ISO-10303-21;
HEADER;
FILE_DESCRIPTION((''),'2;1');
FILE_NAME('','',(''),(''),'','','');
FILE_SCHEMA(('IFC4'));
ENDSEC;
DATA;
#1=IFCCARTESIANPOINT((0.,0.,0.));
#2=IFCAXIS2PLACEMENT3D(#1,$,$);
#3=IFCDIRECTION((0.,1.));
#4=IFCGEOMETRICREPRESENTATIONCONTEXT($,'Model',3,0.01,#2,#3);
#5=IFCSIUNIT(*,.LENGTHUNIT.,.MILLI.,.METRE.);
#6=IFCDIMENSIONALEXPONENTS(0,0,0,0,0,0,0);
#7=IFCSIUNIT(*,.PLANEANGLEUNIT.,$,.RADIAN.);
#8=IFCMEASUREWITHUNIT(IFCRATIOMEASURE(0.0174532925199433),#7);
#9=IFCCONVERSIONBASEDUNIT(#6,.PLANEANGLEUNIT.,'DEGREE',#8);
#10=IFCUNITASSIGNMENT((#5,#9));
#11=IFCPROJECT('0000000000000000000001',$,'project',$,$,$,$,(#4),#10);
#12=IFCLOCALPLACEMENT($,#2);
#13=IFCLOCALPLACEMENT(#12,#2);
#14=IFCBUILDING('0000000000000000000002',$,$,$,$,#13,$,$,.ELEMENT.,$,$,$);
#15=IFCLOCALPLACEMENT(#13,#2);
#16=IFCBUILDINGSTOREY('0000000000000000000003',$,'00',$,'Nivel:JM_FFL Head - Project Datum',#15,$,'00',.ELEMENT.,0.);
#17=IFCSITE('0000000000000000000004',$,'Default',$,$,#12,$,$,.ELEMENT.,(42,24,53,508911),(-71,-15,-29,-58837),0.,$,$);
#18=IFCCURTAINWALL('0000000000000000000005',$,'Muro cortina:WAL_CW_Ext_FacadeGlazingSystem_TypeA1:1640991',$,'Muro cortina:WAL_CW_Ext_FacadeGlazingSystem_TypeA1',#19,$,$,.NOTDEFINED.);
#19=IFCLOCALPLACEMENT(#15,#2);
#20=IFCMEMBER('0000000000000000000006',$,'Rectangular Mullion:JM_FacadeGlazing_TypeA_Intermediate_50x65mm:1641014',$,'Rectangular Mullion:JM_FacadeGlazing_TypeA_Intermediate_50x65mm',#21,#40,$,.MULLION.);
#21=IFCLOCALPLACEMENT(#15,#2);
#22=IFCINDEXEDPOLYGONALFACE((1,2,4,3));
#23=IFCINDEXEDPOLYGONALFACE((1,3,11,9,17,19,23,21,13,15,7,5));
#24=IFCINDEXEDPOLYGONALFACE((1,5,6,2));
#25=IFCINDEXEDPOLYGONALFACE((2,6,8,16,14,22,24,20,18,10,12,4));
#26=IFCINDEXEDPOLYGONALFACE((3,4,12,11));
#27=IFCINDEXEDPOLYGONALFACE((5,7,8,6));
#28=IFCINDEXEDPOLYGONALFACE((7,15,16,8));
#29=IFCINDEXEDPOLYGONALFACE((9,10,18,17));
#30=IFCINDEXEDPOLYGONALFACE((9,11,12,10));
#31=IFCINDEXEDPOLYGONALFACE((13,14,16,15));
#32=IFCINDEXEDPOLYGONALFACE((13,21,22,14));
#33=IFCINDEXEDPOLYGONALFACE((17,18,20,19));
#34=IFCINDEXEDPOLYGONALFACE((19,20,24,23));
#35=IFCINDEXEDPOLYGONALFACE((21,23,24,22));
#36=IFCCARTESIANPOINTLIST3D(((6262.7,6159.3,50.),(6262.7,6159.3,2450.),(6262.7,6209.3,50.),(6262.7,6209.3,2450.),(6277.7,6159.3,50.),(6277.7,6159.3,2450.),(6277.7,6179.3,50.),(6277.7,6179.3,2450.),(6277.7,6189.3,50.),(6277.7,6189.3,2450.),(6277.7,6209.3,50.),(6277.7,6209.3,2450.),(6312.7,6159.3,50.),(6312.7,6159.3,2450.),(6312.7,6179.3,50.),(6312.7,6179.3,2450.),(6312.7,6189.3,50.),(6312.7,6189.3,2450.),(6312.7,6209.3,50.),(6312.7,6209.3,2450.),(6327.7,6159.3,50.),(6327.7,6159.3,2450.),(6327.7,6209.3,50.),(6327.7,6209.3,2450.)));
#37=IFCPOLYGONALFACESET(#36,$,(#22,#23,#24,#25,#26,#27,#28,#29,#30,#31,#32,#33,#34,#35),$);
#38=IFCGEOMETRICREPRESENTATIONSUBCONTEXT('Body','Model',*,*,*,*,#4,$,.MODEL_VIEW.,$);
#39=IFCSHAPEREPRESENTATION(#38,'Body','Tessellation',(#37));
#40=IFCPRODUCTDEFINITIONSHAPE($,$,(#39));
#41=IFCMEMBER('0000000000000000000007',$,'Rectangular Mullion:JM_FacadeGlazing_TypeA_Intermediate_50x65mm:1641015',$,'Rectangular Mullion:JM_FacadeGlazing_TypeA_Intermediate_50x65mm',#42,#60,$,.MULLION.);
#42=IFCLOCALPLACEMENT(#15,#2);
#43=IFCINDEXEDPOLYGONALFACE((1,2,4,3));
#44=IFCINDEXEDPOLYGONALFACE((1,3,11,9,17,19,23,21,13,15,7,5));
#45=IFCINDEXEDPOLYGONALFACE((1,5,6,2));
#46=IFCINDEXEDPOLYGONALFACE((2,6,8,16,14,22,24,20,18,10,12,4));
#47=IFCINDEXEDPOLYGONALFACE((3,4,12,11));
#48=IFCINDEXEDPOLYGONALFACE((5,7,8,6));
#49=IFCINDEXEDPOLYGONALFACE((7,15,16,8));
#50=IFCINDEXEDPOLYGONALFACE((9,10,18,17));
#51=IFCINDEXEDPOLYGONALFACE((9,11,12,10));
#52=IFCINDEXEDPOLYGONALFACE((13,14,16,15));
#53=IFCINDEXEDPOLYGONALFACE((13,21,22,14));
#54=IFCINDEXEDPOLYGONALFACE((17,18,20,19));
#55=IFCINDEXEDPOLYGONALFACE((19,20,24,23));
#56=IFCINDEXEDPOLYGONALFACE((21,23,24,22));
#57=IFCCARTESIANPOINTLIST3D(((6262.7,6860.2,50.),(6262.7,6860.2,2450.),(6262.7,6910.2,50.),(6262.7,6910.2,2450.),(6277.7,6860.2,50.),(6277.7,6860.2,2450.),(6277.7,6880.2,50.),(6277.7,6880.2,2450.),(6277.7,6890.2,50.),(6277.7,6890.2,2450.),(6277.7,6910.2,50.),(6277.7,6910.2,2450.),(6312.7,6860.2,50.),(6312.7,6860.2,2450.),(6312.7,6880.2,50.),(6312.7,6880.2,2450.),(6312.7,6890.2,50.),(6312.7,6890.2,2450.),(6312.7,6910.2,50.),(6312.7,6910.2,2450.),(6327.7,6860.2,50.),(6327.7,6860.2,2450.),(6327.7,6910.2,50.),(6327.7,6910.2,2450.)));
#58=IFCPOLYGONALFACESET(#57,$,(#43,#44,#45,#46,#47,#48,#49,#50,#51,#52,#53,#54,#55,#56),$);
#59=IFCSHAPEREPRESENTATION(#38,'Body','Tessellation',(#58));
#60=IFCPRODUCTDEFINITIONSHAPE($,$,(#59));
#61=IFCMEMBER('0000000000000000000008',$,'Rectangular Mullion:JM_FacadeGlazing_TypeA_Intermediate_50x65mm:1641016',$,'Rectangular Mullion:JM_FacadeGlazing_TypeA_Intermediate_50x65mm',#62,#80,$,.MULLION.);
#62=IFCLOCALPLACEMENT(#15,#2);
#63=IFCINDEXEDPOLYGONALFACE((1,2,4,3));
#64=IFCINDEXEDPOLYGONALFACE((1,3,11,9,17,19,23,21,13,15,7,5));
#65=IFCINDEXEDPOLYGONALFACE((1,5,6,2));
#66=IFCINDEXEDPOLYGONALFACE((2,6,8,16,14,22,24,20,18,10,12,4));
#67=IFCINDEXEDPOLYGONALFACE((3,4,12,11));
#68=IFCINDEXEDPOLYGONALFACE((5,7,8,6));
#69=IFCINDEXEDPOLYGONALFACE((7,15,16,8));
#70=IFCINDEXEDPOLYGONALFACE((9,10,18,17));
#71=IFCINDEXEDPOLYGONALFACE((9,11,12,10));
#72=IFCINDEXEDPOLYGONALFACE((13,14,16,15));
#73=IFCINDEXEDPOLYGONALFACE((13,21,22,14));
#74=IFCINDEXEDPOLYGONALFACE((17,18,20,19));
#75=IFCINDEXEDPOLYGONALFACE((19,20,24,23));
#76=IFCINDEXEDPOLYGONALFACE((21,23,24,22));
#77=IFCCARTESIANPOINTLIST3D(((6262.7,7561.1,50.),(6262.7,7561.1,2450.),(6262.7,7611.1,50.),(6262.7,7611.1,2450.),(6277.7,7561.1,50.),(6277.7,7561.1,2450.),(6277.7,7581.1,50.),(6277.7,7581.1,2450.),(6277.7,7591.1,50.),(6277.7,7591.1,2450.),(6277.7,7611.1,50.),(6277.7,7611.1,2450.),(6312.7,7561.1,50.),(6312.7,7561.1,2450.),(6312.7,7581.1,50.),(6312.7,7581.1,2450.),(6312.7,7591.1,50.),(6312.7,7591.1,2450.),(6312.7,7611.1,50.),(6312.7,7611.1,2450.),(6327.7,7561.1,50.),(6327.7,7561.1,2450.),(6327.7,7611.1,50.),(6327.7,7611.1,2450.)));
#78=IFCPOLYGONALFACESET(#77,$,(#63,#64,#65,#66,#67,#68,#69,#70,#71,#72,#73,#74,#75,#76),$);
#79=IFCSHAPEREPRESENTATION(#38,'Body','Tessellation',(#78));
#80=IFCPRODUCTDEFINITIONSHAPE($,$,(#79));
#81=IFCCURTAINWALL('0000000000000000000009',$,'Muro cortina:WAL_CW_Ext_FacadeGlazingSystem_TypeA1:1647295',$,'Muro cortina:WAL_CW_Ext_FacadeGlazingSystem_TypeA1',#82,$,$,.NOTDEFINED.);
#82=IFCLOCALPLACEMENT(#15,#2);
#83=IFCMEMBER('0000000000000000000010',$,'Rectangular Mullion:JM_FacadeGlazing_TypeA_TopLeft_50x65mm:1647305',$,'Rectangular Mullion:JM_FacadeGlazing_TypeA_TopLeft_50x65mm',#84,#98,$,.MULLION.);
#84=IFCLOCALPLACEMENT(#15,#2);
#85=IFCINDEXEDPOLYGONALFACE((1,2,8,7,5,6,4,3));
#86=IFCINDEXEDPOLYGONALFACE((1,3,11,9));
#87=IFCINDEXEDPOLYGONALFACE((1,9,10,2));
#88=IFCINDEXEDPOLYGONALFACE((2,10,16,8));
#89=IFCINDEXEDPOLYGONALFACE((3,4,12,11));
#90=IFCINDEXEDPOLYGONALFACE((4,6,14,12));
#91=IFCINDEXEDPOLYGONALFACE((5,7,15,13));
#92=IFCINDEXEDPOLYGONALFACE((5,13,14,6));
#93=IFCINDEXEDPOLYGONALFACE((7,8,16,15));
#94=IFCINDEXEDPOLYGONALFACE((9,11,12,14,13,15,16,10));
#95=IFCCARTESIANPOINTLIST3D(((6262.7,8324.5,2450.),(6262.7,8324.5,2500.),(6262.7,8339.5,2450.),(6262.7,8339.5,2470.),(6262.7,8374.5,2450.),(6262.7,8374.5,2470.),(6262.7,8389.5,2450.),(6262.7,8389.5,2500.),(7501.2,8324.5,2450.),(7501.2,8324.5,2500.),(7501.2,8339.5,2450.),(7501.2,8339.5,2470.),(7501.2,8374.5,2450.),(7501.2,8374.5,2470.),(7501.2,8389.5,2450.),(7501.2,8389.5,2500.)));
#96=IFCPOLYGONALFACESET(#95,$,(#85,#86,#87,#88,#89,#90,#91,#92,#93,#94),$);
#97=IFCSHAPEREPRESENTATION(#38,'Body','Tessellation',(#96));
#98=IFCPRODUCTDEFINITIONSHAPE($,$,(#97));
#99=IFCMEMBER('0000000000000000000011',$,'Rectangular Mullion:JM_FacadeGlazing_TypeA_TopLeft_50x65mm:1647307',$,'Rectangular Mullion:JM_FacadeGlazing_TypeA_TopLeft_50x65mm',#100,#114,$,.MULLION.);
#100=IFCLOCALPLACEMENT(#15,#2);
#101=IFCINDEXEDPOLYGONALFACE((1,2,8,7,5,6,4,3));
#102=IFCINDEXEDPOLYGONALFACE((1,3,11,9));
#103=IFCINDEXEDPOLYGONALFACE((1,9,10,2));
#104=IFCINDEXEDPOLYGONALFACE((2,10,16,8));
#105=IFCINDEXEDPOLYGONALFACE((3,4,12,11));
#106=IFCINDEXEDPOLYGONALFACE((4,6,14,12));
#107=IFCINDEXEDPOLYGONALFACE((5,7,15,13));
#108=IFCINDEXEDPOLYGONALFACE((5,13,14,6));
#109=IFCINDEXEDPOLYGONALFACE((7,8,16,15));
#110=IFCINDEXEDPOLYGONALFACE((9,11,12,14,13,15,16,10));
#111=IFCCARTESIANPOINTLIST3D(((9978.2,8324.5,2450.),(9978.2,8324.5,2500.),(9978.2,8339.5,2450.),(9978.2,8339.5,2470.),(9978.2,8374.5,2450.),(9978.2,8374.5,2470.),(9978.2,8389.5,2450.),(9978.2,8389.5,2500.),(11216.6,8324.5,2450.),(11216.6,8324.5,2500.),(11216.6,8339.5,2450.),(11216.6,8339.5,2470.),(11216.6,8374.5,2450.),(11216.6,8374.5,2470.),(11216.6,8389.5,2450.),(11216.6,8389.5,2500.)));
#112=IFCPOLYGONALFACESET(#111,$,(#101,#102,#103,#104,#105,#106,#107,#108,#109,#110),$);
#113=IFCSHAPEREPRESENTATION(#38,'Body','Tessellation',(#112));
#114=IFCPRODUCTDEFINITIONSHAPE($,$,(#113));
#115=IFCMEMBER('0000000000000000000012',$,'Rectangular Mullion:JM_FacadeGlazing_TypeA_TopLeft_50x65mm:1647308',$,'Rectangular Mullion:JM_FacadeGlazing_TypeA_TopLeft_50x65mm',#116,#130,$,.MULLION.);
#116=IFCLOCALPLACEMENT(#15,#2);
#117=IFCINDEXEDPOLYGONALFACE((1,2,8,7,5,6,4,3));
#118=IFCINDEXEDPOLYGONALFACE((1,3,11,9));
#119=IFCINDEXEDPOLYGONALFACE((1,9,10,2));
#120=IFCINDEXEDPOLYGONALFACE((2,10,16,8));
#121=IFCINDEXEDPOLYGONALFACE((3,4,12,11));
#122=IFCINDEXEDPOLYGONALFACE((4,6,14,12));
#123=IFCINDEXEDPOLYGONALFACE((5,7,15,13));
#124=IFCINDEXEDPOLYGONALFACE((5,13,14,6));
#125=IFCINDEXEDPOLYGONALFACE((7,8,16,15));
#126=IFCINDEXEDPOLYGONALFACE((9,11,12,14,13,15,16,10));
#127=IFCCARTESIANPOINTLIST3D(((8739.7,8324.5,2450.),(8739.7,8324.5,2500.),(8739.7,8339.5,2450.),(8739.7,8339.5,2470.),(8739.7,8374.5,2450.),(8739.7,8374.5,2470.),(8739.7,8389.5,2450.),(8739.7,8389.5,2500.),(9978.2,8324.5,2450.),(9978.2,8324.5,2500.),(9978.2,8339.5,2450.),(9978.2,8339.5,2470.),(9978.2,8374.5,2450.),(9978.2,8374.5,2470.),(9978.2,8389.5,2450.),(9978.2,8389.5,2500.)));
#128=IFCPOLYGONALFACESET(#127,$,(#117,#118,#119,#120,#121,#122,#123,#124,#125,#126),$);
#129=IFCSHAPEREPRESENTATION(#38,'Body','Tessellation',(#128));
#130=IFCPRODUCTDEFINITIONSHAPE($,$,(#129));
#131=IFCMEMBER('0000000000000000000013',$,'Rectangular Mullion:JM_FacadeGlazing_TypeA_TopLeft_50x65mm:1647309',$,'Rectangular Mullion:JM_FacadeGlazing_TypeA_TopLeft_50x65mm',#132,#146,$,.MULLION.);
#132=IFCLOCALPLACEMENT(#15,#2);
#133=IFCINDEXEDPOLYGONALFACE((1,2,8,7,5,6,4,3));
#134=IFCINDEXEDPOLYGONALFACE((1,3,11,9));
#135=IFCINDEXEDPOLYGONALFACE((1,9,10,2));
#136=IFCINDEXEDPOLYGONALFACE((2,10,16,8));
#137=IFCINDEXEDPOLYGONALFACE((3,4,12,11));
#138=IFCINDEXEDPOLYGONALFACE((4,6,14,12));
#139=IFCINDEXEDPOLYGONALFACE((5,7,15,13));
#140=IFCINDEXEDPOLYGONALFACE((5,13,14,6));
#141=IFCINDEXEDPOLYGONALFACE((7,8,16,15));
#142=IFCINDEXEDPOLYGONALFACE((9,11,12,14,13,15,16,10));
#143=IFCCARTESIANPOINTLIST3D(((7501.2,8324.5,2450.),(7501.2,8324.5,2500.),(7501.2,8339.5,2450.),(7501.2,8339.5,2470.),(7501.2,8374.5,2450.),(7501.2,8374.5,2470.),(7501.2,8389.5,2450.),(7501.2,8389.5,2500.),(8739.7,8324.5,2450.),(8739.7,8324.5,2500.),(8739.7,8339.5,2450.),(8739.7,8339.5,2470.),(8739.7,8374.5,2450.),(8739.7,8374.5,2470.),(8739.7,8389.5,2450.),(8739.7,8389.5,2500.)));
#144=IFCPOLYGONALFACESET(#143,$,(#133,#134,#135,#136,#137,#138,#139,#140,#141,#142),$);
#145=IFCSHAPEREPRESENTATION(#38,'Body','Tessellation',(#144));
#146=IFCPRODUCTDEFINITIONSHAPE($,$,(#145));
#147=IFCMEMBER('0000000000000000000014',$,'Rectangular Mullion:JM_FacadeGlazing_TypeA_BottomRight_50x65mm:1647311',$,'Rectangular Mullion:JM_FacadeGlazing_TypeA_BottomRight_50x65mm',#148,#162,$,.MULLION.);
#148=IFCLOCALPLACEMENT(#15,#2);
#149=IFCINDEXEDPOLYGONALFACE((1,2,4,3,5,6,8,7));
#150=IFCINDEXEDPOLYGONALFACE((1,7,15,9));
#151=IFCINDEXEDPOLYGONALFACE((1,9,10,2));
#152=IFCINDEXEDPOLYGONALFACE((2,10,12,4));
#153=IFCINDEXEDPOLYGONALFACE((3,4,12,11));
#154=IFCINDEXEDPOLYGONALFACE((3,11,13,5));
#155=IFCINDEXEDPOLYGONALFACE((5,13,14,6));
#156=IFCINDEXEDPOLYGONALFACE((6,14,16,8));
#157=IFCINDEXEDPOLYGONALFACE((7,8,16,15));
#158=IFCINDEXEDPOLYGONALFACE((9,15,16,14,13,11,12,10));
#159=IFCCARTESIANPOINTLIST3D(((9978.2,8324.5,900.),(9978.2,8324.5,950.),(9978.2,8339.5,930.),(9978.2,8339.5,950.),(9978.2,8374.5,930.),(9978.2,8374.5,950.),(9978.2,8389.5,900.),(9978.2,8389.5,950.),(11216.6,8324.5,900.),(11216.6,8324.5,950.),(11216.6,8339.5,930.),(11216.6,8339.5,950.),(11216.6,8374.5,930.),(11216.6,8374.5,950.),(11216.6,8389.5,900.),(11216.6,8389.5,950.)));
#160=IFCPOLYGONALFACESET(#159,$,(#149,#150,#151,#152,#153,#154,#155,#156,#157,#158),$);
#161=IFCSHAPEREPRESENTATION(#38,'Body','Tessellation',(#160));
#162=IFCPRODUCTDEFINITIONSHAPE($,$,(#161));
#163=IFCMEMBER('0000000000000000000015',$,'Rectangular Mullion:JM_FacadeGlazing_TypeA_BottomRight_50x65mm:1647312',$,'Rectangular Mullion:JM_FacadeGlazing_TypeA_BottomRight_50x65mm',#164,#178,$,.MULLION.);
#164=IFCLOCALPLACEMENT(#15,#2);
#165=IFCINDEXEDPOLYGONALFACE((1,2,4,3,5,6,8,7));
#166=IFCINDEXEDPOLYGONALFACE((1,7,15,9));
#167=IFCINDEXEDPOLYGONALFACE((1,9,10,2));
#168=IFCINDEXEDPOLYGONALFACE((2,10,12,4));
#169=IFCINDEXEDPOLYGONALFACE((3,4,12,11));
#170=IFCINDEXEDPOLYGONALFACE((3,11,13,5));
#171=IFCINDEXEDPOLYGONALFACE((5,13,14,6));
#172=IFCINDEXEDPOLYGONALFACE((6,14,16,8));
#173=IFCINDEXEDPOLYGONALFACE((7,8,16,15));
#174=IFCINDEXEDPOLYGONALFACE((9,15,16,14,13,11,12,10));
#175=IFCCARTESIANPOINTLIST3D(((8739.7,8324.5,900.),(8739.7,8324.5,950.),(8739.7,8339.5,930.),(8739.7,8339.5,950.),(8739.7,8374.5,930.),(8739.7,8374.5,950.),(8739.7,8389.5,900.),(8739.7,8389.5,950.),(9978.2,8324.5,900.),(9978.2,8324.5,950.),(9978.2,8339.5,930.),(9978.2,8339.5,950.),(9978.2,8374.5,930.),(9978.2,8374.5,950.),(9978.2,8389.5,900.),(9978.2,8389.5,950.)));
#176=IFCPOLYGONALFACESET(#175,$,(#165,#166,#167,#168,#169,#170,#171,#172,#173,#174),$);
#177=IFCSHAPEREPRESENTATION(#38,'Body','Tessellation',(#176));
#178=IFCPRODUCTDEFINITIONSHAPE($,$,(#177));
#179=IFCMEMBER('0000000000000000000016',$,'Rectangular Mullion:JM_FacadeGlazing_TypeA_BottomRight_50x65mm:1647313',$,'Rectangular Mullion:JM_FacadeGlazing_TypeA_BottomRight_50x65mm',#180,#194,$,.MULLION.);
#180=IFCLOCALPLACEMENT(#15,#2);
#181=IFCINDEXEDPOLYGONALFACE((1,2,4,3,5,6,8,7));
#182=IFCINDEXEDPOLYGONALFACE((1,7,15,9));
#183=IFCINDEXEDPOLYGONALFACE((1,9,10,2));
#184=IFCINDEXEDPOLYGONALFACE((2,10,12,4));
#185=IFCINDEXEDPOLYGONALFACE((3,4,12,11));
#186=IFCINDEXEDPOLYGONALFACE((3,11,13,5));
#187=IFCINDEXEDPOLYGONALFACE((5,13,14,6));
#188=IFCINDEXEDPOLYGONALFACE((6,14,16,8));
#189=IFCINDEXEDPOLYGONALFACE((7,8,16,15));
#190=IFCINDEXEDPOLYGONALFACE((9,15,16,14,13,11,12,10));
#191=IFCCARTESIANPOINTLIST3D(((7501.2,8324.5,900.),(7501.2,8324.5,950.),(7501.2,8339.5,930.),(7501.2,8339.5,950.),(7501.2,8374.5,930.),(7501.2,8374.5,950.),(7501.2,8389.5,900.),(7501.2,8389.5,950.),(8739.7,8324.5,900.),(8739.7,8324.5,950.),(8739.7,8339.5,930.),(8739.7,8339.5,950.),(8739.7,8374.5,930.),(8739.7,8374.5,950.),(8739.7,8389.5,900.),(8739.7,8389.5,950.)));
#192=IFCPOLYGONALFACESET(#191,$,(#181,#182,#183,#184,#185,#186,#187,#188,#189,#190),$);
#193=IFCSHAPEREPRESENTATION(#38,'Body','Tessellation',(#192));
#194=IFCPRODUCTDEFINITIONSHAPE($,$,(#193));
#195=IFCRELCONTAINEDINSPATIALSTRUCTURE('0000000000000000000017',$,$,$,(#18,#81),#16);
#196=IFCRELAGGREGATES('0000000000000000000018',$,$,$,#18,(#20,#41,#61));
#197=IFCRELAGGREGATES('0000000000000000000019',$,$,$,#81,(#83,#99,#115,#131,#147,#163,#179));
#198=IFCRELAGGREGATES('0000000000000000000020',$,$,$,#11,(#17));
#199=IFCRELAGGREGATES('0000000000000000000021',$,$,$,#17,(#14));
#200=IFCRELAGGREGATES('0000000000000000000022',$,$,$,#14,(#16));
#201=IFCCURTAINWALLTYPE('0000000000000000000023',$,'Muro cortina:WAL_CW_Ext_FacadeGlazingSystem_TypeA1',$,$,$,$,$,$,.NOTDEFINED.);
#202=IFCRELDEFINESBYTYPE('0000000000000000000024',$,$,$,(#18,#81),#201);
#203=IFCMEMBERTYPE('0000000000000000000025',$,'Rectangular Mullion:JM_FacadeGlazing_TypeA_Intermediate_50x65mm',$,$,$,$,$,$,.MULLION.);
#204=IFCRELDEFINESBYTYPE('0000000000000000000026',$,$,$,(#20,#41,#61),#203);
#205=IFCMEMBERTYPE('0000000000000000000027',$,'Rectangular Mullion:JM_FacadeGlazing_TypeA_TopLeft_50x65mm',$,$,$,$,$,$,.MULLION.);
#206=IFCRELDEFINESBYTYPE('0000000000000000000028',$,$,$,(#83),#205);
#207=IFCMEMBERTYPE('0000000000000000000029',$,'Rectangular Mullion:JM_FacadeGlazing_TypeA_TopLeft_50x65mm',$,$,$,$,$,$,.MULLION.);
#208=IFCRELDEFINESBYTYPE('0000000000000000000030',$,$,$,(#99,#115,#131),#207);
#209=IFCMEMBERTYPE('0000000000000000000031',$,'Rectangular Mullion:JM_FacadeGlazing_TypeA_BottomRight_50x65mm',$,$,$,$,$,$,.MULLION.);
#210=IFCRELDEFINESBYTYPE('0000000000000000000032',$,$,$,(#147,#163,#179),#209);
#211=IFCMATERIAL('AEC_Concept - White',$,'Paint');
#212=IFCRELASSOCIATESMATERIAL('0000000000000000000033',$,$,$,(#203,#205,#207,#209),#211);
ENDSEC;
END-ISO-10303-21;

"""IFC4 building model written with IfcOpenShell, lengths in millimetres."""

from ifc_helpers import new_model, entity, si_unit, converted_unit, direction, frame, origin, place, context, subcontext, project, spatial, indexed_curve, outline, extrude, source, transform, mapped, material, type_object, type_shapes, element, aggregate, save


model = new_model("IFC4")

# Units and contexts
model_context = context("Model", 3, precision=0.01, world=origin(), true_north=direction((0.0, 1.0)))
body_context = subcontext(model_context, "Body", "Model", "MODEL_VIEW")
ifc_project = project(units=[si_unit("LENGTHUNIT", "METRE", prefix="MILLI"), converted_unit("PLANEANGLEUNIT", "DEGREE", entity("IfcRatioMeasure", 0.0174532925199433), si_unit("PLANEANGLEUNIT", "RADIAN"), dimensions=[0, 0, 0, 0, 0, 0, 0])], contexts=[model_context])

# Site, building, storey
site_placement = place(None, origin())
site = spatial("IfcSite", under=ifc_project, at=site_placement, Name="Default", CompositionType="ELEMENT", RefLatitude=(42, 24, 53, 508911), RefLongitude=(-71, -15, -29, -58837), RefElevation=0.0)
building_placement = place(site_placement, origin())
building = spatial("IfcBuilding", under=site, at=building_placement, CompositionType="ELEMENT")
storey_placement = place(building_placement, origin())
storey = spatial("IfcBuildingStorey", under=building, at=storey_placement, Name="00", ObjectType="Nivel:JM_FFL Head - Project Datum", LongName="00", CompositionType="ELEMENT", Elevation=0.0)

# Curtain wall, members
curtain_wall_type = type_object("IfcCurtainWallType", Name="Muro cortina:WAL_CW_Ext_FacadeGlazingSystem_TypeA1", PredefinedType="NOTDEFINED")
curtain_wall_1_placement = place(storey_placement, origin())
curtain_wall_1 = element("IfcCurtainWall", 1, at=curtain_wall_1_placement, inside=storey, type_object=curtain_wall_type, Name="Muro cortina:WAL_CW_Ext_FacadeGlazingSystem_TypeA1:1640991", ObjectType="Muro cortina:WAL_CW_Ext_FacadeGlazingSystem_TypeA1", PredefinedType="NOTDEFINED")
ifc_material_1 = material(Name="AEC_Concept - White", Category="Paint")
member_type_1 = type_object("IfcMemberType", Name="Rectangular Mullion:JM_FacadeGlazing_TypeA_Intermediate_50x65mm", PredefinedType="MULLION", material=ifc_material_1)
shared_shape_1 = source(origin(), body_context, "Body", "SweptSolid", [
    extrude(outline(indexed_curve([(-32.5, -25.0), (-17.5, -25.0), (-17.5, -5.0), (17.5, -5.0), (17.5, -25.0), (32.5, -25.0), (32.5, 25.0), (17.5, 25.0), (17.5, 5.0), (-17.5, 5.0), (-17.5, 25.0), (-32.5, 25.0), (-32.5, -25.0)], self_intersect=False)), frame((0.0, 32.5, -2400.0), z_axis=(0.0, 0.0, 1.0), x_axis=(0.0, -1.0, 0.0)), (0.0, 0.0, 1.0), 2400.0),
])
type_shapes(member_type_1, [shared_shape_1])
member_1_placement = place(curtain_wall_1_placement, frame((6262.7, 6184.3, 50.0), z_axis=(0.0, 0.0, -1.0), x_axis=(0.0, 1.0, 0.0)))
member_1 = element("IfcMember", 2, at=member_1_placement, type_object=member_type_1, Name="Rectangular Mullion:JM_FacadeGlazing_TypeA_Intermediate_50x65mm:1641014", ObjectType="Rectangular Mullion:JM_FacadeGlazing_TypeA_Intermediate_50x65mm", PredefinedType="MULLION", context=body_context, shape_type="MappedRepresentation", body=[
    mapped(shared_shape_1, transform((0.0, 0.0, 0.0), scale=1.0)),
])
member_2_placement = place(curtain_wall_1_placement, frame((6262.7, 6885.2, 50.0), z_axis=(0.0, 0.0, -1.0), x_axis=(0.0, 1.0, 0.0)))
member_2 = element("IfcMember", 3, at=member_2_placement, type_object=member_type_1, Name="Rectangular Mullion:JM_FacadeGlazing_TypeA_Intermediate_50x65mm:1641015", ObjectType="Rectangular Mullion:JM_FacadeGlazing_TypeA_Intermediate_50x65mm", PredefinedType="MULLION", context=body_context, shape_type="MappedRepresentation", body=[
    mapped(shared_shape_1, transform((0.0, 0.0, 0.0), scale=1.0)),
])
member_3_placement = place(curtain_wall_1_placement, frame((6262.7, 7586.1, 50.0), z_axis=(0.0, 0.0, -1.0), x_axis=(0.0, 1.0, 0.0)))
member_3 = element("IfcMember", 4, at=member_3_placement, type_object=member_type_1, Name="Rectangular Mullion:JM_FacadeGlazing_TypeA_Intermediate_50x65mm:1641016", ObjectType="Rectangular Mullion:JM_FacadeGlazing_TypeA_Intermediate_50x65mm", PredefinedType="MULLION", context=body_context, shape_type="MappedRepresentation", body=[
    mapped(shared_shape_1, transform((0.0, 0.0, 0.0), scale=1.0)),
])
aggregate(curtain_wall_1, [member_1, member_2, member_3])

# Curtain wall, members
curtain_wall_2_placement = place(storey_placement, origin())
curtain_wall_2 = element("IfcCurtainWall", 5, at=curtain_wall_2_placement, inside=storey, type_object=curtain_wall_type, Name="Muro cortina:WAL_CW_Ext_FacadeGlazingSystem_TypeA1:1647295", ObjectType="Muro cortina:WAL_CW_Ext_FacadeGlazingSystem_TypeA1", PredefinedType="NOTDEFINED")
member_type_2 = type_object("IfcMemberType", Name="Rectangular Mullion:JM_FacadeGlazing_TypeA_TopLeft_50x65mm", PredefinedType="MULLION", material=ifc_material_1)
shared_shape_2 = source(origin(), body_context, "Body", "SweptSolid", [
    extrude(outline(indexed_curve([(-32.5, -17.5), (-17.5, -17.5), (-17.5, 2.5), (17.5, 2.5), (17.5, -17.5), (32.5, -17.5), (32.5, 32.5), (-32.5, 32.5), (-32.5, -17.5)], self_intersect=False)), frame((-32.5, -32.5, -1238.5), z_axis=(0.0, 0.0, 1.0), x_axis=(0.0, -1.0, 0.0)), (0.0, 0.0, 1.0), 1238.5),
])
type_shapes(member_type_2, [shared_shape_2])
member_4_placement = place(curtain_wall_2_placement, frame((6262.7, 8389.5, 2500.0), z_axis=(-1.0, 0.0, 0.0), x_axis=(0.0, 0.0, 1.0)))
member_4 = element("IfcMember", 6, at=member_4_placement, type_object=member_type_2, Name="Rectangular Mullion:JM_FacadeGlazing_TypeA_TopLeft_50x65mm:1647305", ObjectType="Rectangular Mullion:JM_FacadeGlazing_TypeA_TopLeft_50x65mm", PredefinedType="MULLION", context=body_context, shape_type="MappedRepresentation", body=[
    mapped(shared_shape_2, transform((0.0, 0.0, 0.0), scale=1.0)),
])
member_type_3 = type_object("IfcMemberType", Name="Rectangular Mullion:JM_FacadeGlazing_TypeA_TopLeft_50x65mm", PredefinedType="MULLION", material=ifc_material_1)
shared_shape_3 = source(origin(), body_context, "Body", "SweptSolid", [
    extrude(outline(indexed_curve([(-32.5, -17.5), (-17.5, -17.5), (-17.5, 2.5), (17.5, 2.5), (17.5, -17.5), (32.5, -17.5), (32.5, 32.5), (-32.5, 32.5), (-32.5, -17.5)], self_intersect=False)), frame((-32.5, -32.5, -1238.5), z_axis=(0.0, 0.0, 1.0), x_axis=(0.0, -1.0, 0.0)), (0.0, 0.0, 1.0), 1238.5),
])
type_shapes(member_type_3, [shared_shape_3])
member_5_placement = place(curtain_wall_2_placement, frame((9978.2, 8389.5, 2500.0), z_axis=(-1.0, 0.0, 0.0), x_axis=(0.0, 0.0, 1.0)))
member_5 = element("IfcMember", 7, at=member_5_placement, type_object=member_type_3, Name="Rectangular Mullion:JM_FacadeGlazing_TypeA_TopLeft_50x65mm:1647307", ObjectType="Rectangular Mullion:JM_FacadeGlazing_TypeA_TopLeft_50x65mm", PredefinedType="MULLION", context=body_context, shape_type="MappedRepresentation", body=[
    mapped(shared_shape_3, transform((0.0, 0.0, 0.0), scale=1.0)),
])
member_6_placement = place(curtain_wall_2_placement, frame((8739.7, 8389.5, 2500.0), z_axis=(-1.0, 0.0, 0.0), x_axis=(0.0, 0.0, 1.0)))
member_6 = element("IfcMember", 8, at=member_6_placement, type_object=member_type_3, Name="Rectangular Mullion:JM_FacadeGlazing_TypeA_TopLeft_50x65mm:1647308", ObjectType="Rectangular Mullion:JM_FacadeGlazing_TypeA_TopLeft_50x65mm", PredefinedType="MULLION", context=body_context, shape_type="MappedRepresentation", body=[
    mapped(shared_shape_3, transform((0.0, 0.0, 0.0), scale=1.0)),
])
member_7_placement = place(curtain_wall_2_placement, frame((7501.2, 8389.5, 2500.0), z_axis=(-1.0, 0.0, 0.0), x_axis=(0.0, 0.0, 1.0)))
member_7 = element("IfcMember", 9, at=member_7_placement, type_object=member_type_3, Name="Rectangular Mullion:JM_FacadeGlazing_TypeA_TopLeft_50x65mm:1647309", ObjectType="Rectangular Mullion:JM_FacadeGlazing_TypeA_TopLeft_50x65mm", PredefinedType="MULLION", context=body_context, shape_type="MappedRepresentation", body=[
    mapped(shared_shape_3, transform((0.0, 0.0, 0.0), scale=1.0)),
])
member_type_4 = type_object("IfcMemberType", Name="Rectangular Mullion:JM_FacadeGlazing_TypeA_BottomRight_50x65mm", PredefinedType="MULLION", material=ifc_material_1)
shared_shape_4 = source(origin(), body_context, "Body", "SweptSolid", [
    extrude(outline(indexed_curve([(-32.5, -17.5), (-17.5, -17.5), (-17.5, 2.5), (17.5, 2.5), (17.5, -17.5), (32.5, -17.5), (32.5, 32.5), (-32.5, 32.5), (-32.5, -17.5)], self_intersect=False)), frame((-32.5, -32.5, -1238.5), z_axis=(0.0, 0.0, 1.0), x_axis=(0.0, -1.0, 0.0)), (0.0, 0.0, 1.0), 1238.5),
])
type_shapes(member_type_4, [shared_shape_4])
member_8_placement = place(curtain_wall_2_placement, frame((11216.6, 8389.5, 900.0), z_axis=(1.0, 0.0, 0.0), x_axis=(0.0, 0.0, -1.0)))
member_8 = element("IfcMember", 10, at=member_8_placement, type_object=member_type_4, Name="Rectangular Mullion:JM_FacadeGlazing_TypeA_BottomRight_50x65mm:1647311", ObjectType="Rectangular Mullion:JM_FacadeGlazing_TypeA_BottomRight_50x65mm", PredefinedType="MULLION", context=body_context, shape_type="MappedRepresentation", body=[
    mapped(shared_shape_4, transform((0.0, 0.0, 0.0), scale=1.0)),
])
member_9_placement = place(curtain_wall_2_placement, frame((9978.2, 8389.5, 900.0), z_axis=(1.0, 0.0, 0.0), x_axis=(0.0, 0.0, -1.0)))
member_9 = element("IfcMember", 11, at=member_9_placement, type_object=member_type_4, Name="Rectangular Mullion:JM_FacadeGlazing_TypeA_BottomRight_50x65mm:1647312", ObjectType="Rectangular Mullion:JM_FacadeGlazing_TypeA_BottomRight_50x65mm", PredefinedType="MULLION", context=body_context, shape_type="MappedRepresentation", body=[
    mapped(shared_shape_4, transform((0.0, 0.0, 0.0), scale=1.0)),
])
member_10_placement = place(curtain_wall_2_placement, frame((8739.7, 8389.5, 900.0), z_axis=(1.0, 0.0, 0.0), x_axis=(0.0, 0.0, -1.0)))
member_10 = element("IfcMember", 12, at=member_10_placement, type_object=member_type_4, Name="Rectangular Mullion:JM_FacadeGlazing_TypeA_BottomRight_50x65mm:1647313", ObjectType="Rectangular Mullion:JM_FacadeGlazing_TypeA_BottomRight_50x65mm", PredefinedType="MULLION", context=body_context, shape_type="MappedRepresentation", body=[
    mapped(shared_shape_4, transform((0.0, 0.0, 0.0), scale=1.0)),
])
aggregate(curtain_wall_2, [member_4, member_5, member_6, member_7, member_8, member_9, member_10])

save(model, "model.ifc")
